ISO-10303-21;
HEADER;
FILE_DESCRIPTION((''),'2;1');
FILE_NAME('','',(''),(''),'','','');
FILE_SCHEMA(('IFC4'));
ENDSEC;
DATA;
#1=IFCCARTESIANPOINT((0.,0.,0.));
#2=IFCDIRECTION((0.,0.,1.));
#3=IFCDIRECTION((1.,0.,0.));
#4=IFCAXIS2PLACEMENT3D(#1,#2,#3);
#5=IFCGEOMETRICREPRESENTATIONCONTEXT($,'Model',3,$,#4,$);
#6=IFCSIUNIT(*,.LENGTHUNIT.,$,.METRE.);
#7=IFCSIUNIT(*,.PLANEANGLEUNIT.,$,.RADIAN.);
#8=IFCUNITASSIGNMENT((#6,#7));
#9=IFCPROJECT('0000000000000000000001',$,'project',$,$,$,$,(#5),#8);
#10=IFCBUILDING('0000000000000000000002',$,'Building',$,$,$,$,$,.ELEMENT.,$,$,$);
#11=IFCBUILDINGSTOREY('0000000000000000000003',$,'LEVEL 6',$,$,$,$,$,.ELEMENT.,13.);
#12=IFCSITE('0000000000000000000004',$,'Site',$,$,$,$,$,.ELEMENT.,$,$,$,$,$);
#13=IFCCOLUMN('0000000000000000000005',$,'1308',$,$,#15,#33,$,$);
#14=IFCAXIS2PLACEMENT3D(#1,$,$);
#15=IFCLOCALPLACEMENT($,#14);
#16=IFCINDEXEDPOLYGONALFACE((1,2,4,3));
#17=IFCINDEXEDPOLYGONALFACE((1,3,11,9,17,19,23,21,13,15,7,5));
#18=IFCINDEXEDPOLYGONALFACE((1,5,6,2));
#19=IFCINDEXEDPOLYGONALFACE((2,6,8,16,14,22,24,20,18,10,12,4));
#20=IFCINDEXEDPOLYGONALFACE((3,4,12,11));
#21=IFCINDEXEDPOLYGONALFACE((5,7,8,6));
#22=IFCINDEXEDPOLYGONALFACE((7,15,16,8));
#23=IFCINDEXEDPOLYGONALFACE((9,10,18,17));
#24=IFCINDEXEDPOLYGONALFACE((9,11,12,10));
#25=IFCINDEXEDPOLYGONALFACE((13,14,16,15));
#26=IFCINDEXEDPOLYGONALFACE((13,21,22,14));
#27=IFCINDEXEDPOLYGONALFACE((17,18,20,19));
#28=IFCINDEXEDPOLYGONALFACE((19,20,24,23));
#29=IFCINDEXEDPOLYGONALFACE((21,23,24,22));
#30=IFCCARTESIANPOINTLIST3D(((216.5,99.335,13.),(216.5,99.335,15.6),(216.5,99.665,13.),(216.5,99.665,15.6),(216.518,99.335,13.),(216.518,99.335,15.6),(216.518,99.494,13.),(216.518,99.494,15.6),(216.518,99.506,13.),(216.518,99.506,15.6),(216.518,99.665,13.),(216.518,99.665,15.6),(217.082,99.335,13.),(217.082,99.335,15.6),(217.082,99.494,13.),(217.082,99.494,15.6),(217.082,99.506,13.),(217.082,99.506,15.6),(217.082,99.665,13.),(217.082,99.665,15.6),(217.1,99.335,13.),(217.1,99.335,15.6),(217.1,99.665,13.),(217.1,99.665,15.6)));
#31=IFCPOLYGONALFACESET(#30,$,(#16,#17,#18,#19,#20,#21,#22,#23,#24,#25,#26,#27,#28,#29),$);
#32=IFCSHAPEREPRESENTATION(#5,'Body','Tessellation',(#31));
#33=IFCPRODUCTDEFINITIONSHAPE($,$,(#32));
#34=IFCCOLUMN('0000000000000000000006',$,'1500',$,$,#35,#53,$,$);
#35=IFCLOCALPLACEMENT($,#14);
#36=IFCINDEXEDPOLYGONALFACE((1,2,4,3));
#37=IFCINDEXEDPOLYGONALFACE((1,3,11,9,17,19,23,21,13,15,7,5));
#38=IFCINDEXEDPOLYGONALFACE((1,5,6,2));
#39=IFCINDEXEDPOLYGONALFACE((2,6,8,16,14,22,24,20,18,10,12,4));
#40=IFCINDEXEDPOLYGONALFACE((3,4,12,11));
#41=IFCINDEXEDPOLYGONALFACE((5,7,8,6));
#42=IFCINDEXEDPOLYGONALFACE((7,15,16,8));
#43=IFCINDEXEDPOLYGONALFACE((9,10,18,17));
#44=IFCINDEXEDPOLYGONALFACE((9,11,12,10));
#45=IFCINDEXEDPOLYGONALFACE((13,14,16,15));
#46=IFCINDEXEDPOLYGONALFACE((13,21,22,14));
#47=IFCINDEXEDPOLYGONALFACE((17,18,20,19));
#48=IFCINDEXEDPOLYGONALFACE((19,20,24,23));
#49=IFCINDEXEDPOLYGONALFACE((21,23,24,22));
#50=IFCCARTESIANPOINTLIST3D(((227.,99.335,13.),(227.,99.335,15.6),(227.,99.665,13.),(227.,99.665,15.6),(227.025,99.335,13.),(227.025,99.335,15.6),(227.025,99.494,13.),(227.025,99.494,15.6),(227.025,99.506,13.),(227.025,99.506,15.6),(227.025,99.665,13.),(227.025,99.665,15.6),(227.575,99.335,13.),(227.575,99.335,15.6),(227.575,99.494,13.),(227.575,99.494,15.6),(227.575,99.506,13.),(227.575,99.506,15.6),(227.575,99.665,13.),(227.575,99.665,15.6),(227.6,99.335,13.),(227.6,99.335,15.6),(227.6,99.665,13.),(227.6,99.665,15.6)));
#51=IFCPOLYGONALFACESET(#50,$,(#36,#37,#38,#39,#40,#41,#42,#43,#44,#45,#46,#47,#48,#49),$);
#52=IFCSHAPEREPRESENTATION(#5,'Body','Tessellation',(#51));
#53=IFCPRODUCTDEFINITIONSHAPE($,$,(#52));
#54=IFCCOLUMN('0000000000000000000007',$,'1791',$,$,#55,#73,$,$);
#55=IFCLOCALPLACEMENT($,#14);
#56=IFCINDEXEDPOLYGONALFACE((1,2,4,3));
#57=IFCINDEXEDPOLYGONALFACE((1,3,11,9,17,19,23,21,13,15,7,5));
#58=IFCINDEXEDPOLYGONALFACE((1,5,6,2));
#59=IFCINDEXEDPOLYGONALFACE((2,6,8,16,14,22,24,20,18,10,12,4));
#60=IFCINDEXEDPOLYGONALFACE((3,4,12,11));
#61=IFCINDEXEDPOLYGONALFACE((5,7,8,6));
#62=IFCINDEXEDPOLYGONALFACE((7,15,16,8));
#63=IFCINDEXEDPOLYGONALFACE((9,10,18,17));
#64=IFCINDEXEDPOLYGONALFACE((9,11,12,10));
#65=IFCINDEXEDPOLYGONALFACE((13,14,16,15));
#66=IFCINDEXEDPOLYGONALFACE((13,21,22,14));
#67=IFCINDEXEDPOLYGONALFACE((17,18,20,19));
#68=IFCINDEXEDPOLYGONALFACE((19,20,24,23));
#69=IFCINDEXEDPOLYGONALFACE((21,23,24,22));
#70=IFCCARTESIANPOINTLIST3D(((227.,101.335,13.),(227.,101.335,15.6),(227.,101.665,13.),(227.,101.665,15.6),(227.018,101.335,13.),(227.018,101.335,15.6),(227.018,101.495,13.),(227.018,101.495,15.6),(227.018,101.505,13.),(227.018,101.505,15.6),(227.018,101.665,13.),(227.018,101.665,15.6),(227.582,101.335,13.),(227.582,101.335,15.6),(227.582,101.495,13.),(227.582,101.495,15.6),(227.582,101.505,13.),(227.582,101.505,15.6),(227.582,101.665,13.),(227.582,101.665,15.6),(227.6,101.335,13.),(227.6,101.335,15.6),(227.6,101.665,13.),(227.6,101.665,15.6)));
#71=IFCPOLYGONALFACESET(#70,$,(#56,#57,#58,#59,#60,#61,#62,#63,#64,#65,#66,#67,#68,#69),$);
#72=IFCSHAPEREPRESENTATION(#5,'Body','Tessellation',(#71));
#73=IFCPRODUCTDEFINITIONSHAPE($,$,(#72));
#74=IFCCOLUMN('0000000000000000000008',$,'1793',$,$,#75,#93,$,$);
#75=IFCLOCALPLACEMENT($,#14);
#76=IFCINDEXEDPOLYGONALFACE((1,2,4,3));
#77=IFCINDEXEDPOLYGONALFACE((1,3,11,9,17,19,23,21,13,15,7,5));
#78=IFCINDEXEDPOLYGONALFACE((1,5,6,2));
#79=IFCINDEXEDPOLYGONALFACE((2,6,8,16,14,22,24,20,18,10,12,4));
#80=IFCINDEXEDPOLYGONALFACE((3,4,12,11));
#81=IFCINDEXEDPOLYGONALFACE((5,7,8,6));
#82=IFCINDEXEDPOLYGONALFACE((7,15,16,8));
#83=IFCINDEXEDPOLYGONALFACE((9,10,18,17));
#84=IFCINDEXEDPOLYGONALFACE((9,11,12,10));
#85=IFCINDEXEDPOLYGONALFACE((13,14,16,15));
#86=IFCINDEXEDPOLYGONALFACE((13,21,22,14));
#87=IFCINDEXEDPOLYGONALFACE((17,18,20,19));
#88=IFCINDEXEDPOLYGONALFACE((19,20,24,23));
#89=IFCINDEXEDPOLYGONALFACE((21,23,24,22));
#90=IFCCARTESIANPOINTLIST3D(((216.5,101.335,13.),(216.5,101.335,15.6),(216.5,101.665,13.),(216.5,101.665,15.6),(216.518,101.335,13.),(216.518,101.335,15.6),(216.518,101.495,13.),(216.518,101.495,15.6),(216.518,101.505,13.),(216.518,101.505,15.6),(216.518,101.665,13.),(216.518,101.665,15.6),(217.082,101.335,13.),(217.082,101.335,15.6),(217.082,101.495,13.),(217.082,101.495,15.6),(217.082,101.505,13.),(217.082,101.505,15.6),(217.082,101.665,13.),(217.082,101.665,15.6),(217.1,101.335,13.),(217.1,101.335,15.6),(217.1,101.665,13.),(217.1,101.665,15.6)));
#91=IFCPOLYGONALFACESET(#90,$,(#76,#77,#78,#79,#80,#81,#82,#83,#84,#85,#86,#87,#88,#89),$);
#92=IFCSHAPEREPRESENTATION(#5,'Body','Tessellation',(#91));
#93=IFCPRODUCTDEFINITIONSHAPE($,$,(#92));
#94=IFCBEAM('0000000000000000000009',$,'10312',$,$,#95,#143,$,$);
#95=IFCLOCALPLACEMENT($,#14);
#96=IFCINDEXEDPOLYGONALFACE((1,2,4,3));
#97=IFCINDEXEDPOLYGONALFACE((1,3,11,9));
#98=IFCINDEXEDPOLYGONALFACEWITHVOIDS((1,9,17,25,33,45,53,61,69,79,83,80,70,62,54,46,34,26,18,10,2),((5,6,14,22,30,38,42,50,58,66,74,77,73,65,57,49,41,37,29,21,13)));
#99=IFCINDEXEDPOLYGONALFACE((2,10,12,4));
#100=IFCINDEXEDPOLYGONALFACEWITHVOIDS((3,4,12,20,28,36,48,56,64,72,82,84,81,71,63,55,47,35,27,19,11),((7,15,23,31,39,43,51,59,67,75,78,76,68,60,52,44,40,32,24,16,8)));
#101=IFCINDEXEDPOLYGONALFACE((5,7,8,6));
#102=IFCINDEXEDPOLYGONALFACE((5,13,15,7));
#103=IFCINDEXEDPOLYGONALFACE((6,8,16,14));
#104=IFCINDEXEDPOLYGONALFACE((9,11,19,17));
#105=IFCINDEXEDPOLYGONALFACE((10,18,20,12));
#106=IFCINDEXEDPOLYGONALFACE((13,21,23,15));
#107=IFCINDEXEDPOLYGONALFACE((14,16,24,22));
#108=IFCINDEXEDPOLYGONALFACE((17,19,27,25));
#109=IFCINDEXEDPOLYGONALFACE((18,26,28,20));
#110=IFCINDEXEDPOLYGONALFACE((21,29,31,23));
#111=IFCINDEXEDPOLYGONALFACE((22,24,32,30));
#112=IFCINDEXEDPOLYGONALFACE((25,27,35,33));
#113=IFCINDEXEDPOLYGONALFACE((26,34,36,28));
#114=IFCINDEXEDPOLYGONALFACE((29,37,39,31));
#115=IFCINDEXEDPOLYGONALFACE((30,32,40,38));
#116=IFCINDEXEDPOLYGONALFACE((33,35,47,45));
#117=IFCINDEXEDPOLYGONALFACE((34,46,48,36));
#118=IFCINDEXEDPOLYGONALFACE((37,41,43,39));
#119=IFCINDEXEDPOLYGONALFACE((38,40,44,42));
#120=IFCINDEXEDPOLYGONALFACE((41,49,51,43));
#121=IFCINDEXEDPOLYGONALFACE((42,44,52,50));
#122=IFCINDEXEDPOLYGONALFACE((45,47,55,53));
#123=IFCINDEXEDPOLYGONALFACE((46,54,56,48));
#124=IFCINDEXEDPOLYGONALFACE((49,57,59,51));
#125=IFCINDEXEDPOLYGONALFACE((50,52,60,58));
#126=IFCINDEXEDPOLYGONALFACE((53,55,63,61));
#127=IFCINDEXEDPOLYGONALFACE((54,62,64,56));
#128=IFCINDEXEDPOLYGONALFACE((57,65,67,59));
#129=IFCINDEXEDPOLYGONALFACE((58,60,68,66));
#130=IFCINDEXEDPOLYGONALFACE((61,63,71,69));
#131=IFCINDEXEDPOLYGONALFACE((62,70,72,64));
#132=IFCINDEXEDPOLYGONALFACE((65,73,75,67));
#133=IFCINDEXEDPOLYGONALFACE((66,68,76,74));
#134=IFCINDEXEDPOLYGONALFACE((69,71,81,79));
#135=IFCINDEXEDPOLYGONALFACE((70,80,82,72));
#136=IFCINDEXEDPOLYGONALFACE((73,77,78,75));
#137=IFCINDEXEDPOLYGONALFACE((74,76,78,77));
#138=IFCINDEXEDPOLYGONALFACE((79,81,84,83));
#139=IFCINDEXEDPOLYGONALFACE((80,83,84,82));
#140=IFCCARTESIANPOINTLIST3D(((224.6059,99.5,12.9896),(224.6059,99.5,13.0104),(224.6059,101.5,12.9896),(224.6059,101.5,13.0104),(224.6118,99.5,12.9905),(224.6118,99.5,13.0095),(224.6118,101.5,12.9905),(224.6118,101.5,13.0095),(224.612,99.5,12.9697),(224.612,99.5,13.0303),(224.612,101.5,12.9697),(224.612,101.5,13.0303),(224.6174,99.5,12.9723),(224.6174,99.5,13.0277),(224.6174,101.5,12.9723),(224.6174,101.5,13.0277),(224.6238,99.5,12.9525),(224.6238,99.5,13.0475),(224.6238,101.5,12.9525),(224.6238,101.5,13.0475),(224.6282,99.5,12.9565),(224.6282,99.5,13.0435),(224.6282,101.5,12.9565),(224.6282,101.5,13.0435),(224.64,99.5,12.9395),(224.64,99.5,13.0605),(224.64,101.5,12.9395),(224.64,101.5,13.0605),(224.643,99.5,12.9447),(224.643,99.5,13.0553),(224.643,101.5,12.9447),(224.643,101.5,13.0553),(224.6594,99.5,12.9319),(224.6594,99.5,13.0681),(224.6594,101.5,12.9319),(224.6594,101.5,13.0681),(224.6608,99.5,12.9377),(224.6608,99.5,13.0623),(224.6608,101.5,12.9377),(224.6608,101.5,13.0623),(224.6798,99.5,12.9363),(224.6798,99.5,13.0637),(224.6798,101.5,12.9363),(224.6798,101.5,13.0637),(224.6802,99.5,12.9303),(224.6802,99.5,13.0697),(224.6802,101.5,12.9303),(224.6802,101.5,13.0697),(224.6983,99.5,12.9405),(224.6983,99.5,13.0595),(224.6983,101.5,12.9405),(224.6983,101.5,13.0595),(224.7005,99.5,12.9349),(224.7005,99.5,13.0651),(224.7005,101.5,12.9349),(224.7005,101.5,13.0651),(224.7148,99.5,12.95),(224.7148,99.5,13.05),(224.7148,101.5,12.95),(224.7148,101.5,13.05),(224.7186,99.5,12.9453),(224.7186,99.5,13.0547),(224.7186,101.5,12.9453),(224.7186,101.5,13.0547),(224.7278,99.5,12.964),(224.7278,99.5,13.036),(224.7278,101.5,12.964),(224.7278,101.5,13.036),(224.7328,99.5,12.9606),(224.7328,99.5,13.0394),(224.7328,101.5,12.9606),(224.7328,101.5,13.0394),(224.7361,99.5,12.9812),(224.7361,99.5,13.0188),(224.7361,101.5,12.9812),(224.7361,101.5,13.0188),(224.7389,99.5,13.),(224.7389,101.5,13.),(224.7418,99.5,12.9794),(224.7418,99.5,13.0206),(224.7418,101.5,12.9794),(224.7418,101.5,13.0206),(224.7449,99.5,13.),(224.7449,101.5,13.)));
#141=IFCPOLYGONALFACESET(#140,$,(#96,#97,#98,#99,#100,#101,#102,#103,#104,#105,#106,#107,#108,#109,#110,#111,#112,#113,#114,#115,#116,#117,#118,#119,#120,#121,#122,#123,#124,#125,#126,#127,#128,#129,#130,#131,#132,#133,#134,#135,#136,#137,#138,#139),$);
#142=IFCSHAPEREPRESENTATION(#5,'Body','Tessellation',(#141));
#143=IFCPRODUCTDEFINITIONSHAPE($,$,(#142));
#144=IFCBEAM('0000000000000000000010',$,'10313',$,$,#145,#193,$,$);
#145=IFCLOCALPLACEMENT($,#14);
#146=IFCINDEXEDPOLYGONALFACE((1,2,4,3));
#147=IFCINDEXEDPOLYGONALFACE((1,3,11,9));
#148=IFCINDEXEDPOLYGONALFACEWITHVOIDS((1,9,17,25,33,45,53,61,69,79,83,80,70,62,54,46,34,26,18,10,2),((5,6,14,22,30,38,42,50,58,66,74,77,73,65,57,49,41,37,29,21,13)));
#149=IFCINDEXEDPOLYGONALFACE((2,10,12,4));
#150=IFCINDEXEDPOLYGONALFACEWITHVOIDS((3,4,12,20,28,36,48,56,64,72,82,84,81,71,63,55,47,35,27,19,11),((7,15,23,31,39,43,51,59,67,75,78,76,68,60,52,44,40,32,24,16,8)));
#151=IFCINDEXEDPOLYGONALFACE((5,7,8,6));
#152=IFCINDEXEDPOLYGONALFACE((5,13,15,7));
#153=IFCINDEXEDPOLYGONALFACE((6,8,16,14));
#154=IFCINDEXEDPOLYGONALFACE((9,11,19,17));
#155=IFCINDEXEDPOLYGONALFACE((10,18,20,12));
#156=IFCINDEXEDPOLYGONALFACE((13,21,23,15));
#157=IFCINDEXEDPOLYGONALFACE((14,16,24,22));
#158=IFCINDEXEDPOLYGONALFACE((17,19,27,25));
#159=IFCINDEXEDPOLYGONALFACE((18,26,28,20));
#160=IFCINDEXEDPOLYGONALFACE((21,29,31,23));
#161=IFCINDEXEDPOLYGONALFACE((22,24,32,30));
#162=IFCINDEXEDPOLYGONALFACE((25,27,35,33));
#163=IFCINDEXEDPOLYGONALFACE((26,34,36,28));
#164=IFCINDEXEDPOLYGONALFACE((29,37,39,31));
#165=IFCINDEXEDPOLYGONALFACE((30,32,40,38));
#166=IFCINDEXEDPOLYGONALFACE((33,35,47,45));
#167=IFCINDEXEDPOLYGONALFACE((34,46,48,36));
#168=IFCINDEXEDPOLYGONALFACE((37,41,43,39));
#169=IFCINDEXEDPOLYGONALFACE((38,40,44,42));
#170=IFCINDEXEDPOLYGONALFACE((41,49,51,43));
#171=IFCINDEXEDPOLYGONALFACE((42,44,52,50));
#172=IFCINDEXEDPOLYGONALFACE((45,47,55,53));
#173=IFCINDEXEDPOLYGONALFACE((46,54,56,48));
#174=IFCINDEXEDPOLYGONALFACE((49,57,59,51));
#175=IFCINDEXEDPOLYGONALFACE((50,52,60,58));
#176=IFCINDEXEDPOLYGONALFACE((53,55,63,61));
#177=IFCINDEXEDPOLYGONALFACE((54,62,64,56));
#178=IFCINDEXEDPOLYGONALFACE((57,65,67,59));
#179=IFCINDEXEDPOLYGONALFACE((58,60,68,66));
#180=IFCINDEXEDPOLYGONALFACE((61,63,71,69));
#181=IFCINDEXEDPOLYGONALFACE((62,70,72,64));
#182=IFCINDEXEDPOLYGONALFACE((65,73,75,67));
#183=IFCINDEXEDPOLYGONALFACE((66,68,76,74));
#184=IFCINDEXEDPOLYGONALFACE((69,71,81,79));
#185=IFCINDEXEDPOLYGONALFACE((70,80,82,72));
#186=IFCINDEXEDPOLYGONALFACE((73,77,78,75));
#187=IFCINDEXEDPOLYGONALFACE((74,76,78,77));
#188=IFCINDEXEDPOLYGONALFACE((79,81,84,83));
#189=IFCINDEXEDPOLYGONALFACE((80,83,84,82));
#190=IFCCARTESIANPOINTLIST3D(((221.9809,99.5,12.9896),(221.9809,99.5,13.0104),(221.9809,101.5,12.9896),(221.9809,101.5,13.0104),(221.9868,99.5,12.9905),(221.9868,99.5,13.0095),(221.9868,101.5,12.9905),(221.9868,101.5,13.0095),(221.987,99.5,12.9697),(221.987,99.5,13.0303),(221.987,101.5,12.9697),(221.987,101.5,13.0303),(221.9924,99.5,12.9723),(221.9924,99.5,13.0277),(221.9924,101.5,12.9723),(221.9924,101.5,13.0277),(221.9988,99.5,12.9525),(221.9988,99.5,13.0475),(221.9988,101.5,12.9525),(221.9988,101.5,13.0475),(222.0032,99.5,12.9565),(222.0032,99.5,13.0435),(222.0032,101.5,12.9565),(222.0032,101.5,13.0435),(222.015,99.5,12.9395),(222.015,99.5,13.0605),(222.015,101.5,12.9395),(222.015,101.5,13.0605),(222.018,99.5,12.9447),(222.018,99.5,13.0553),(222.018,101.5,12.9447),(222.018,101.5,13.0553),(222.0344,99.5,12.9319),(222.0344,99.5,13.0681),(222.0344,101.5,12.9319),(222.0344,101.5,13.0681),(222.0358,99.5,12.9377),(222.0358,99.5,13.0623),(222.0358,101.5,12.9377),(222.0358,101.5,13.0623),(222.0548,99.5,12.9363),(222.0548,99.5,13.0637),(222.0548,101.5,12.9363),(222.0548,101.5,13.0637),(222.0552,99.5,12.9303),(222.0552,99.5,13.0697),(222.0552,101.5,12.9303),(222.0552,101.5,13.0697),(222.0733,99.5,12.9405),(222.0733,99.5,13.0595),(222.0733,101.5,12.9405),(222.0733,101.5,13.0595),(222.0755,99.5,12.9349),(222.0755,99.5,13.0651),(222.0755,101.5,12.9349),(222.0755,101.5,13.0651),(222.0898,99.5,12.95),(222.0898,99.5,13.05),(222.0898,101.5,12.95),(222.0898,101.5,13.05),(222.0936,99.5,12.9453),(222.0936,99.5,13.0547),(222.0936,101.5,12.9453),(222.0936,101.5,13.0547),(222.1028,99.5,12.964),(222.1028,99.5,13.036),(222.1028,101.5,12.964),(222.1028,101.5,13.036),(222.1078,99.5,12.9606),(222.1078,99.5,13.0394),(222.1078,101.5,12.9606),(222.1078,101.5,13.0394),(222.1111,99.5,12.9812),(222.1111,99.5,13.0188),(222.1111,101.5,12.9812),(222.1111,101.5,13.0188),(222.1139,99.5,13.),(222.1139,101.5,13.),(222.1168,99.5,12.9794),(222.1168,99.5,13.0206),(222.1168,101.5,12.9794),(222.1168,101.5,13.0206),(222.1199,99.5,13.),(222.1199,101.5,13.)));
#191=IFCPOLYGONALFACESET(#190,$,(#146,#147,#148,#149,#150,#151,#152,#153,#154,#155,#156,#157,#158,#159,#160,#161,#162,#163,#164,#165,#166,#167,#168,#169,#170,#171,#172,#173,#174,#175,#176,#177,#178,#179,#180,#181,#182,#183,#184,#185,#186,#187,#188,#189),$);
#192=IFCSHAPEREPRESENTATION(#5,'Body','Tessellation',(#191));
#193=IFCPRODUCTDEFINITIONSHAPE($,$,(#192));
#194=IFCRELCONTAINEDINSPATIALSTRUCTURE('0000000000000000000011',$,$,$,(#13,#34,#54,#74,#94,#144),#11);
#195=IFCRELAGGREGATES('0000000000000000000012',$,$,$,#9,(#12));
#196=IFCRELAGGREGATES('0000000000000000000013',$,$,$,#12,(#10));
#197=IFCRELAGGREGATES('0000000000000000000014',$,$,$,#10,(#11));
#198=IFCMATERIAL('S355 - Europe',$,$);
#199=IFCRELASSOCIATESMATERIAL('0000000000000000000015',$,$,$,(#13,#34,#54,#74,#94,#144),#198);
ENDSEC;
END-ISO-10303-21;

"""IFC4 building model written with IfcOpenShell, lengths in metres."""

from ifc_helpers import new_model, si_unit, frame, origin_with_axes, origin_2d_with_axis, place, context, project, spatial, hollow_circle, i_section, extrude, material, material_profile, profile_set, profile_usage, element, save


model = new_model("IFC4")

# Units and contexts
model_context = context("Model", 3, world=origin_with_axes())
ifc_project = project(units=[si_unit("LENGTHUNIT", "METRE"), si_unit("PLANEANGLEUNIT", "RADIAN")], contexts=[model_context])

# Site, building, storey
site = spatial("IfcSite", under=ifc_project, Name="Site", CompositionType="ELEMENT")
building = spatial("IfcBuilding", under=site, Name="Building", CompositionType="ELEMENT")
storey = spatial("IfcBuildingStorey", under=building, Name="LEVEL 6", CompositionType="ELEMENT", Elevation=13.0)

# Columns
ifc_material = material(Name="S355 - Europe")
ifc_material_profile_1 = material_profile(ifc_material, i_section(OverallWidth=0.33, OverallDepth=0.6, WebThickness=0.012, FlangeThickness=0.018, at=origin_2d_with_axis()))
ifc_profile_set_1 = profile_set([ifc_material_profile_1])
ifc_profile_usage_1 = profile_usage(ifc_profile_set_1, cardinal=10)
column_1_placement = place(None, frame((216.8, 99.5, 13.0), z_axis=(0.0, 0.0, 1.0), x_axis=(0.0, -1.0, 0.0)))
element("IfcColumn", 1, at=column_1_placement, inside=storey, material=ifc_profile_usage_1, Name="1308", context=model_context, shape_type="SweptSolid", body=[
    extrude(i_section(OverallWidth=0.33, OverallDepth=0.6, WebThickness=0.012, FlangeThickness=0.018, at=origin_2d_with_axis()), origin_with_axes(), (0.0, 0.0, 1.0), 2.6),
])
ifc_material_profile_2 = material_profile(ifc_material, i_section(OverallWidth=0.33, OverallDepth=0.6, WebThickness=0.012, FlangeThickness=0.025, at=origin_2d_with_axis()))
ifc_profile_set_2 = profile_set([ifc_material_profile_2])
ifc_profile_usage_2 = profile_usage(ifc_profile_set_2, cardinal=10)
column_2_placement = place(None, frame((227.3, 99.5, 13.0), z_axis=(0.0, 0.0, 1.0), x_axis=(0.0, -1.0, 0.0)))
element("IfcColumn", 2, at=column_2_placement, inside=storey, material=ifc_profile_usage_2, Name="1500", context=model_context, shape_type="SweptSolid", body=[
    extrude(i_section(OverallWidth=0.33, OverallDepth=0.6, WebThickness=0.012, FlangeThickness=0.025, at=origin_2d_with_axis()), origin_with_axes(), (0.0, 0.0, 1.0), 2.6),
])
ifc_material_profile_3 = material_profile(ifc_material, i_section(OverallWidth=0.33, OverallDepth=0.6, WebThickness=0.01, FlangeThickness=0.018, at=origin_2d_with_axis()))
ifc_profile_set_3 = profile_set([ifc_material_profile_3])
ifc_profile_usage_3 = profile_usage(ifc_profile_set_3, cardinal=10)
column_3_placement = place(None, frame((227.3, 101.5, 13.0), z_axis=(0.0, 0.0, 1.0), x_axis=(0.0, -1.0, 0.0)))
element("IfcColumn", 3, at=column_3_placement, inside=storey, material=ifc_profile_usage_3, Name="1791", context=model_context, shape_type="SweptSolid", body=[
    extrude(i_section(OverallWidth=0.33, OverallDepth=0.6, WebThickness=0.01, FlangeThickness=0.018, at=origin_2d_with_axis()), origin_with_axes(), (0.0, 0.0, 1.0), 2.6),
])
ifc_material_profile_4 = material_profile(ifc_material, i_section(OverallWidth=0.33, OverallDepth=0.6, WebThickness=0.01, FlangeThickness=0.018, at=origin_2d_with_axis()))
ifc_profile_set_4 = profile_set([ifc_material_profile_4])
ifc_profile_usage_4 = profile_usage(ifc_profile_set_4, cardinal=10)
column_4_placement = place(None, frame((216.8, 101.5, 13.0), z_axis=(0.0, 0.0, 1.0), x_axis=(0.0, -1.0, 0.0)))
element("IfcColumn", 4, at=column_4_placement, inside=storey, material=ifc_profile_usage_4, Name="1793", context=model_context, shape_type="SweptSolid", body=[
    extrude(i_section(OverallWidth=0.33, OverallDepth=0.6, WebThickness=0.01, FlangeThickness=0.018, at=origin_2d_with_axis()), origin_with_axes(), (0.0, 0.0, 1.0), 2.6),
])

# Beams
ifc_material_profile_5 = material_profile(ifc_material, hollow_circle(Radius=0.0699, WallThickness=0.006, at=origin_2d_with_axis()))
ifc_profile_set_5 = profile_set([ifc_material_profile_5])
ifc_profile_usage_5 = profile_usage(ifc_profile_set_5, cardinal=10)
beam_1_placement = place(None, frame((224.675, 101.5, 13.0), z_axis=(0.0, -1.0, 0.0), x_axis=(1.0, 0.0, 0.0)))
element("IfcBeam", 5, at=beam_1_placement, inside=storey, material=ifc_profile_usage_5, Name="10312", context=model_context, shape_type="SweptSolid", body=[
    extrude(hollow_circle(Radius=0.0699, WallThickness=0.006, at=origin_2d_with_axis()), origin_with_axes(), (0.0, 0.0, 1.0), 2.0),
])
ifc_material_profile_6 = material_profile(ifc_material, hollow_circle(Radius=0.0699, WallThickness=0.006, at=origin_2d_with_axis()))
ifc_profile_set_6 = profile_set([ifc_material_profile_6])
ifc_profile_usage_6 = profile_usage(ifc_profile_set_6, cardinal=10)
beam_2_placement = place(None, frame((222.05, 101.5, 13.0), z_axis=(0.0, -1.0, 0.0), x_axis=(1.0, 0.0, 0.0)))
element("IfcBeam", 6, at=beam_2_placement, inside=storey, material=ifc_profile_usage_6, Name="10313", context=model_context, shape_type="SweptSolid", body=[
    extrude(hollow_circle(Radius=0.0699, WallThickness=0.006, at=origin_2d_with_axis()), origin_with_axes(), (0.0, 0.0, 1.0), 2.0),
])

save(model, "model.ifc")
